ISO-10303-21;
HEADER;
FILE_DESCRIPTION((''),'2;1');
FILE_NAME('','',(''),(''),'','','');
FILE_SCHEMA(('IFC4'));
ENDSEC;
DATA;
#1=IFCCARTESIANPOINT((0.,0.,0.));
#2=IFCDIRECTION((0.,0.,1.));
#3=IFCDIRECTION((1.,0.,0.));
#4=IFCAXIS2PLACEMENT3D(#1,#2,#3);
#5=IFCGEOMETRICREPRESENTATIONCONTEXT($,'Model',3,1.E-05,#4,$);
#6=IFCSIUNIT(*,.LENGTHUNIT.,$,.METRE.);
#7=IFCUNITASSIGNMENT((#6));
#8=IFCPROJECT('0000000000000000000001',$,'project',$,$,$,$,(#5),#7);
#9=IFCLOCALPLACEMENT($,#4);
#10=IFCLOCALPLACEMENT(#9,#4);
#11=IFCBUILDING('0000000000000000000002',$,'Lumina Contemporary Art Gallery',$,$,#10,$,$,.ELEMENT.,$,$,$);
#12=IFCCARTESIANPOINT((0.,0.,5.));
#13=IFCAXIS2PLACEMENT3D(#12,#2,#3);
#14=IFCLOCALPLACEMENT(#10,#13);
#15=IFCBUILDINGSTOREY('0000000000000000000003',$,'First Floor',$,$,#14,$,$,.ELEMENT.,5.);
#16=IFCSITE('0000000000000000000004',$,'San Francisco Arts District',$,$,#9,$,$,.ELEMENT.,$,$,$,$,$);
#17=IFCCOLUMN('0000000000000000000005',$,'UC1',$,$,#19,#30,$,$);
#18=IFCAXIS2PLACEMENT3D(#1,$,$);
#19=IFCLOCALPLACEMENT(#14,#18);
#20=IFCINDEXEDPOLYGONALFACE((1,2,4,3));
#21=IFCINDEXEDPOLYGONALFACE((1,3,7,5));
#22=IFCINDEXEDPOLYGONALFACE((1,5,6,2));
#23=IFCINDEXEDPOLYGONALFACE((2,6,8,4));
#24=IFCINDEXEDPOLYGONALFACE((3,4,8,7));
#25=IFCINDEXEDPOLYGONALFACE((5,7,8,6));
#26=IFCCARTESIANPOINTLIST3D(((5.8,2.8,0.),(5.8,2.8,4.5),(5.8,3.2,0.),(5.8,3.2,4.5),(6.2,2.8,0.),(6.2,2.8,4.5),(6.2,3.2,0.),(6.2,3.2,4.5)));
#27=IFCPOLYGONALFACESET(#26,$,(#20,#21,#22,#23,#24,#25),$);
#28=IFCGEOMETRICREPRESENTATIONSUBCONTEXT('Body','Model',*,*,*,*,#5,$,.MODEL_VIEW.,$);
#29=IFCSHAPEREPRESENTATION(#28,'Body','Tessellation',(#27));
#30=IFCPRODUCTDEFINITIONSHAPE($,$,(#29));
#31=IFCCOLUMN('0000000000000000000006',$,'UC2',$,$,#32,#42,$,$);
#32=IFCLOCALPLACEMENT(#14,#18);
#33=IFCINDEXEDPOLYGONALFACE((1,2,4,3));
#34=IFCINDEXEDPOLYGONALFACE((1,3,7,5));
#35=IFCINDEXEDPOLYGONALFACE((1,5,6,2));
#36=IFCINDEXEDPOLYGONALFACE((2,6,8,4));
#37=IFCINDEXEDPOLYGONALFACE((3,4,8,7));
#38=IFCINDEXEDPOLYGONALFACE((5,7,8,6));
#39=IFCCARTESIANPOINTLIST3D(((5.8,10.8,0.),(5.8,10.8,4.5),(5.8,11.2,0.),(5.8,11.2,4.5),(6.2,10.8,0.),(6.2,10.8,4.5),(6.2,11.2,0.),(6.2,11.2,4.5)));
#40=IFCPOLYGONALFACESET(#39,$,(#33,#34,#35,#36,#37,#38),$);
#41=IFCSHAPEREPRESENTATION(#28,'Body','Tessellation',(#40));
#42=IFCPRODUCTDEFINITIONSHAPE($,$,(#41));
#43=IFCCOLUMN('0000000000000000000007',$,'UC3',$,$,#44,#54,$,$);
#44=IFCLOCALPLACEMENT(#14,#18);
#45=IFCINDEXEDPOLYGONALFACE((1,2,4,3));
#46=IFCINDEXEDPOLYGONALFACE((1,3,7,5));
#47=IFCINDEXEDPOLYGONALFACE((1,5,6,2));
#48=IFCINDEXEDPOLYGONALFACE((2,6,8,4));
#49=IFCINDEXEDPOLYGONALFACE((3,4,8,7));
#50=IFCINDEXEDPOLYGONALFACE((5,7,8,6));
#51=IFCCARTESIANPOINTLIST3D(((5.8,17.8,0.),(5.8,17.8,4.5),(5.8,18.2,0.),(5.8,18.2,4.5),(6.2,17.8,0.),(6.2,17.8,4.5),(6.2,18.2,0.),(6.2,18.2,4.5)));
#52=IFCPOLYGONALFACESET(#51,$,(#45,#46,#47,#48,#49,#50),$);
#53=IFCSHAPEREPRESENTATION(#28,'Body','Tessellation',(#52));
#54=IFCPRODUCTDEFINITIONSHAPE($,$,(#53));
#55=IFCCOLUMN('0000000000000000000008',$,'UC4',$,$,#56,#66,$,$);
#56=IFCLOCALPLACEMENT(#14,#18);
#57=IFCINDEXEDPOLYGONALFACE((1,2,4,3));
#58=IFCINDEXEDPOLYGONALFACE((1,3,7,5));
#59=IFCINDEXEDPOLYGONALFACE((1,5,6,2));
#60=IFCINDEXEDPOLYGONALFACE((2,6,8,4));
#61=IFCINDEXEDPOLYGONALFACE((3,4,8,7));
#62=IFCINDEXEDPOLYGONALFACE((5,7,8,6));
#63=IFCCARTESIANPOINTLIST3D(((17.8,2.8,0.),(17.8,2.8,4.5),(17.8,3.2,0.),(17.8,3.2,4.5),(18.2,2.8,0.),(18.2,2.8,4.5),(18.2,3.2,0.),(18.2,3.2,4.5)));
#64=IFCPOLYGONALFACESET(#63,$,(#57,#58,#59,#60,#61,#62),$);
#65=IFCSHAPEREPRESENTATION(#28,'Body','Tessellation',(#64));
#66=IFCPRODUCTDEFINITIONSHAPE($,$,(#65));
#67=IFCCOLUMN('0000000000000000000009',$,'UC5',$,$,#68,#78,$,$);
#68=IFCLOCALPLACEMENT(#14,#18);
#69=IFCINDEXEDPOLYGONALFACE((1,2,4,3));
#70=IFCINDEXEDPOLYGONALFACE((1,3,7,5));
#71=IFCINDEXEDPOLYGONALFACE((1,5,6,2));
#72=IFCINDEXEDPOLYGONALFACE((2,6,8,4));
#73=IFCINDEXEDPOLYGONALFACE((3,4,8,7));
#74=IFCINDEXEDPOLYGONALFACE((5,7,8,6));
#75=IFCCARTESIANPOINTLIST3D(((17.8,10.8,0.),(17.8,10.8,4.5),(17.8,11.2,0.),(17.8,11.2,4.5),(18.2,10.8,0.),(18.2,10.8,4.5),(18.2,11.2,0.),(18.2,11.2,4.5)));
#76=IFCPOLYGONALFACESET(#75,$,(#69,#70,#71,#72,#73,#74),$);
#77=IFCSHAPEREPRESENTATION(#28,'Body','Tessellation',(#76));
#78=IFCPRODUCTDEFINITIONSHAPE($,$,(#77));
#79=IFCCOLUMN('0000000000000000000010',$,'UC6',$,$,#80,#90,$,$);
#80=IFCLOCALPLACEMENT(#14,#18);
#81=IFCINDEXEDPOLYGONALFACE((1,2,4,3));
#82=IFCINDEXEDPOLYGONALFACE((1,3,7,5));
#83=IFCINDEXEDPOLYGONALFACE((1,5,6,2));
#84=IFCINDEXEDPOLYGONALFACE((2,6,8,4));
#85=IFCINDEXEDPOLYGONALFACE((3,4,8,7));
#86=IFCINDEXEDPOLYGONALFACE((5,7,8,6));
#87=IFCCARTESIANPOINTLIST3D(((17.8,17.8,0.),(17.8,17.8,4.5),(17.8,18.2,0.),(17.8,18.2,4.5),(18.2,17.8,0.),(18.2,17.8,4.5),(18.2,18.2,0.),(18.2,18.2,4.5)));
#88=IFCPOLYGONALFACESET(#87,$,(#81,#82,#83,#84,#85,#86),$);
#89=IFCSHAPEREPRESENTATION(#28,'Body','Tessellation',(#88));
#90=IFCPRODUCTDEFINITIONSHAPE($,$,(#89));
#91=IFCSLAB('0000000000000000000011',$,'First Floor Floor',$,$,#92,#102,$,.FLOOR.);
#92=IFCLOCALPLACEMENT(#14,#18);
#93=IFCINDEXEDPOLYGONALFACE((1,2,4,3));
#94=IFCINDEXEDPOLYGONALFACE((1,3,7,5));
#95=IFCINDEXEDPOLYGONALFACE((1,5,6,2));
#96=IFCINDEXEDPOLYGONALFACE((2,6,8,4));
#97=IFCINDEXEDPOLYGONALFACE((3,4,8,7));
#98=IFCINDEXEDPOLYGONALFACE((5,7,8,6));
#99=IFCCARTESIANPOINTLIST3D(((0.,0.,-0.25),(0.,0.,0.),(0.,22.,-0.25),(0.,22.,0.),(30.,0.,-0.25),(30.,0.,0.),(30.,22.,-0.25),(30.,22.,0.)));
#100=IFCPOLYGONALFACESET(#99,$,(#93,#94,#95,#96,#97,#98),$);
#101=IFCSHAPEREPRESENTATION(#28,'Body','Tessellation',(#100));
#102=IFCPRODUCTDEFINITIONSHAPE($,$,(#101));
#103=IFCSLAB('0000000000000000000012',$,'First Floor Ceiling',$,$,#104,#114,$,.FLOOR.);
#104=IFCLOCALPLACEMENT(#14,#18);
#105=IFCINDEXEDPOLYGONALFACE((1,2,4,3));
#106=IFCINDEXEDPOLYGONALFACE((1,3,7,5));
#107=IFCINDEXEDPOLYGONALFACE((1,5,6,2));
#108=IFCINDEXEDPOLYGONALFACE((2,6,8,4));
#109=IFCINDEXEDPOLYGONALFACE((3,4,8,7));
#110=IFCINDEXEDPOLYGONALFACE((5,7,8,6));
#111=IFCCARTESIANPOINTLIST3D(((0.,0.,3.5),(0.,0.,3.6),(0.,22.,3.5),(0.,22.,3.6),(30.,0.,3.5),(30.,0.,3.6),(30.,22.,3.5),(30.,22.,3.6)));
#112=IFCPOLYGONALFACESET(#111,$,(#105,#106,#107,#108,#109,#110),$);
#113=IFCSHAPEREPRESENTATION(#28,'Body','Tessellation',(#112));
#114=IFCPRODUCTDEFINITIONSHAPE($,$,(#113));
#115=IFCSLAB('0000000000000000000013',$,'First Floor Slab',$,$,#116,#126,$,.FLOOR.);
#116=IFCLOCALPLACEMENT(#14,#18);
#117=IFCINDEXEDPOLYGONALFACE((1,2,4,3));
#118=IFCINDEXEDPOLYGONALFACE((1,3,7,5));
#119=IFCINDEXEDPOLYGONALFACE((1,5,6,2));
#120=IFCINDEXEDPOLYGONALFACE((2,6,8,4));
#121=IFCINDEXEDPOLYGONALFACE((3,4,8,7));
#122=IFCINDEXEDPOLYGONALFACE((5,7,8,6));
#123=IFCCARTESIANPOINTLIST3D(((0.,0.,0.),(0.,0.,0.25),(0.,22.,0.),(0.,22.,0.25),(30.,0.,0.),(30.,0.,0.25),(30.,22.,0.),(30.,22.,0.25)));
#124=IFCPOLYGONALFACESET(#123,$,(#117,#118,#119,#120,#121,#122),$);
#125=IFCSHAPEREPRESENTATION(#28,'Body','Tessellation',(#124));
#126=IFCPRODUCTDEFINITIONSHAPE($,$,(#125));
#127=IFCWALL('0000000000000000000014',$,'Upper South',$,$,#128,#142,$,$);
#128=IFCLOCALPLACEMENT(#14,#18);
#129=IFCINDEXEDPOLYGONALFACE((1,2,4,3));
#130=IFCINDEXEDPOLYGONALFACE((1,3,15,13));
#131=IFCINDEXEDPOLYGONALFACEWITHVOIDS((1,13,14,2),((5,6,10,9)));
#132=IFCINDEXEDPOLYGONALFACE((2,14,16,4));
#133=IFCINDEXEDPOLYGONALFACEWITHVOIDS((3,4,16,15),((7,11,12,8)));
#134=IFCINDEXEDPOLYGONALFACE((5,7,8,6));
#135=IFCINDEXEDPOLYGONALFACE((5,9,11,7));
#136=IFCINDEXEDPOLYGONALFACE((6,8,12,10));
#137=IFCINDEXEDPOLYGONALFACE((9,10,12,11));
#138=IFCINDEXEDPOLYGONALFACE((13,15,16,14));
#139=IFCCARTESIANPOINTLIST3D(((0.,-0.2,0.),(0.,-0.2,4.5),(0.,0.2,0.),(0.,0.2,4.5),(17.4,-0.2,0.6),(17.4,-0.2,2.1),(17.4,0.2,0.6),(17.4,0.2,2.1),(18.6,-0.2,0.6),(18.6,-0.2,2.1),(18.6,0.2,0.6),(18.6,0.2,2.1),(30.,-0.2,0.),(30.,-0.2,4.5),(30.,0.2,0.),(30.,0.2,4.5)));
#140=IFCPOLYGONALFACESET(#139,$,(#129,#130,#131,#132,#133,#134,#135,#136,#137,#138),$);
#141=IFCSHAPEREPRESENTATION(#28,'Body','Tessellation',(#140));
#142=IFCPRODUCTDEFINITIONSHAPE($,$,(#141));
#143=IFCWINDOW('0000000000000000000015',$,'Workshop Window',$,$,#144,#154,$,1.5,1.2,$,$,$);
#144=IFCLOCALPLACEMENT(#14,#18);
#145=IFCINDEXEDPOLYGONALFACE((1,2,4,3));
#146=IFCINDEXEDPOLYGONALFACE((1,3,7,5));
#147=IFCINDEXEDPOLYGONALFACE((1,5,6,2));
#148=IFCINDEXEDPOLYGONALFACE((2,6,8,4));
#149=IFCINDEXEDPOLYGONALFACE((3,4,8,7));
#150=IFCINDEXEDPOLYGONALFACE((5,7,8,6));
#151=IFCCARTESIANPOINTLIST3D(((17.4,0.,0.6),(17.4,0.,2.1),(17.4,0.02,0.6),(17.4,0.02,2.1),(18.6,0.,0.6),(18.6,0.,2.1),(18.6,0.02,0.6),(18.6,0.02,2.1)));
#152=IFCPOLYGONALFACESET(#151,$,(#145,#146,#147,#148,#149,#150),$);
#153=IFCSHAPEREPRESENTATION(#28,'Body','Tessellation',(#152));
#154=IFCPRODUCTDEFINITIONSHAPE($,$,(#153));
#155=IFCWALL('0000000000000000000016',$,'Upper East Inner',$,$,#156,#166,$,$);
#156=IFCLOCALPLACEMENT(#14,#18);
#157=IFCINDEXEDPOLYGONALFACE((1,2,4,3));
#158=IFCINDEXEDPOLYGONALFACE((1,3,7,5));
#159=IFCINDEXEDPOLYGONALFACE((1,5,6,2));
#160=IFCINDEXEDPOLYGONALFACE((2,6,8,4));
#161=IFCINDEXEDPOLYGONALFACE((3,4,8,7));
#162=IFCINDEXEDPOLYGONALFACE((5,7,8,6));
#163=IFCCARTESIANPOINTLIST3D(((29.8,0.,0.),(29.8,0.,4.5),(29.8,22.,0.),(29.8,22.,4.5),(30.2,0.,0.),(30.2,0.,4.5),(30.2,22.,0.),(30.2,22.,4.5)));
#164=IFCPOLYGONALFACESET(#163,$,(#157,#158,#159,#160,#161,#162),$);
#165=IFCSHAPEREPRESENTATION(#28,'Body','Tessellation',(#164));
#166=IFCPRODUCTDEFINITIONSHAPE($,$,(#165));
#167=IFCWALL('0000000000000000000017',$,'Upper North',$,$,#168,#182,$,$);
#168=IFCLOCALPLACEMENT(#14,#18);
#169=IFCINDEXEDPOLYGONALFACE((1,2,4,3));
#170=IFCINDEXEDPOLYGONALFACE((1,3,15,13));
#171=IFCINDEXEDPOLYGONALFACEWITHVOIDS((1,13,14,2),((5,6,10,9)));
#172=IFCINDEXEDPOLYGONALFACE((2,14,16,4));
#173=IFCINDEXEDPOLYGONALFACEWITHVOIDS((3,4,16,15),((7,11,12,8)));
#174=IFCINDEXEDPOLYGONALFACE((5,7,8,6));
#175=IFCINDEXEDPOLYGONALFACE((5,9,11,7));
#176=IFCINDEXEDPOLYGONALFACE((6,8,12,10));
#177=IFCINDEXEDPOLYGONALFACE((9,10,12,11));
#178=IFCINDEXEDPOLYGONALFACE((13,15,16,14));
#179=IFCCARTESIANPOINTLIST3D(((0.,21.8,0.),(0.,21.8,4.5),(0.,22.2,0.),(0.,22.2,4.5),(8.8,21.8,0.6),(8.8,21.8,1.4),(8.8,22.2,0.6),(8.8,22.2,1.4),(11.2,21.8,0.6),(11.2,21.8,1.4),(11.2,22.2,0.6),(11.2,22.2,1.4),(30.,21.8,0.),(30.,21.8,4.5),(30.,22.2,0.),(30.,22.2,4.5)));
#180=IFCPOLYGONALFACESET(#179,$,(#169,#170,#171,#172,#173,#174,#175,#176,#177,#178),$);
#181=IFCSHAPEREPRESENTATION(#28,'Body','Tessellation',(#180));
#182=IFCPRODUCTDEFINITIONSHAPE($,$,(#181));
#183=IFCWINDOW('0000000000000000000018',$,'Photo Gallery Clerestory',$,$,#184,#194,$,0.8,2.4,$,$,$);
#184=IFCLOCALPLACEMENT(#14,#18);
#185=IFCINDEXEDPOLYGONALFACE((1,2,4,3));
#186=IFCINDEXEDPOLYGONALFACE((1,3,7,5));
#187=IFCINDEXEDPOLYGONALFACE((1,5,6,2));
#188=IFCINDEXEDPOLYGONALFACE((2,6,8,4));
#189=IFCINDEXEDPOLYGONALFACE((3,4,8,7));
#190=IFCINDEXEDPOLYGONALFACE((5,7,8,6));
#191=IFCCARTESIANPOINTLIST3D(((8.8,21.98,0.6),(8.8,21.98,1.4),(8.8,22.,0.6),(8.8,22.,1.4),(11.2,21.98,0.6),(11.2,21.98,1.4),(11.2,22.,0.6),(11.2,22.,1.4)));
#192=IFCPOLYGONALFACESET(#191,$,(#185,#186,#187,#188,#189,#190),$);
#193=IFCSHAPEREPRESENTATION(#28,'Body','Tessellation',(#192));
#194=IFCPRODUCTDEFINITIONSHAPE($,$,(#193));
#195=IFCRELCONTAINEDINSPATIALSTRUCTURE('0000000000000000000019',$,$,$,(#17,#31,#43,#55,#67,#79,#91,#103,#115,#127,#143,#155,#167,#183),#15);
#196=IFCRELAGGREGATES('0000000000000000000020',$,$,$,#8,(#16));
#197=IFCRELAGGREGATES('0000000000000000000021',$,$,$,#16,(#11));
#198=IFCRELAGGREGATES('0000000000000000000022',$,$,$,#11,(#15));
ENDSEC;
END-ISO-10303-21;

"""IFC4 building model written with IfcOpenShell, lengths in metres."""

from ifc_helpers import new_model, si_unit, frame, origin_with_axes, place, context, subcontext, project, spatial, polyline, outline, extrude, element, fill, save


model = new_model("IFC4")

# Units and contexts
model_context = context("Model", 3, precision=1e-05, world=origin_with_axes())
body_context = subcontext(model_context, "Body", "Model", "MODEL_VIEW")
ifc_project = project(units=[si_unit("LENGTHUNIT", "METRE")], contexts=[model_context])

# Site, building, storey
site_placement = place(None, origin_with_axes())
site = spatial("IfcSite", under=ifc_project, at=site_placement, Name="San Francisco Arts District", CompositionType="ELEMENT")
building_placement = place(site_placement, origin_with_axes())
building = spatial("IfcBuilding", under=site, at=building_placement, Name="Lumina Contemporary Art Gallery", CompositionType="ELEMENT")
storey_placement = place(building_placement, frame((0.0, 0.0, 5.0), z_axis=(0.0, 0.0, 1.0), x_axis=(1.0, 0.0, 0.0)))
storey = spatial("IfcBuildingStorey", under=building, at=storey_placement, Name="First Floor", CompositionType="ELEMENT", Elevation=5.0)

# Columns
column_1_placement = place(storey_placement, origin_with_axes())
element("IfcColumn", 1, at=column_1_placement, inside=storey, Name="UC1", context=body_context, shape_type="SweptSolid", body=[
    extrude(outline(polyline([(5.8, 2.8, 0.0), (6.2, 2.8, 0.0), (6.2, 3.2, 0.0), (5.8, 3.2, 0.0), (5.8, 2.8, 0.0)])), None, (0.0, 0.0, 1.0), 4.5),
])
column_2_placement = place(storey_placement, origin_with_axes())
element("IfcColumn", 2, at=column_2_placement, inside=storey, Name="UC2", context=body_context, shape_type="SweptSolid", body=[
    extrude(outline(polyline([(5.8, 10.8, 0.0), (6.2, 10.8, 0.0), (6.2, 11.2, 0.0), (5.8, 11.2, 0.0), (5.8, 10.8, 0.0)])), None, (0.0, 0.0, 1.0), 4.5),
])
column_3_placement = place(storey_placement, origin_with_axes())
element("IfcColumn", 3, at=column_3_placement, inside=storey, Name="UC3", context=body_context, shape_type="SweptSolid", body=[
    extrude(outline(polyline([(5.8, 17.8, 0.0), (6.2, 17.8, 0.0), (6.2, 18.2, 0.0), (5.8, 18.2, 0.0), (5.8, 17.8, 0.0)])), None, (0.0, 0.0, 1.0), 4.5),
])
column_4_placement = place(storey_placement, origin_with_axes())
element("IfcColumn", 4, at=column_4_placement, inside=storey, Name="UC4", context=body_context, shape_type="SweptSolid", body=[
    extrude(outline(polyline([(17.8, 2.8, 0.0), (18.2, 2.8, 0.0), (18.2, 3.2, 0.0), (17.8, 3.2, 0.0), (17.8, 2.8, 0.0)])), None, (0.0, 0.0, 1.0), 4.5),
])
column_5_placement = place(storey_placement, origin_with_axes())
element("IfcColumn", 5, at=column_5_placement, inside=storey, Name="UC5", context=body_context, shape_type="SweptSolid", body=[
    extrude(outline(polyline([(17.8, 10.8, 0.0), (18.2, 10.8, 0.0), (18.2, 11.2, 0.0), (17.8, 11.2, 0.0), (17.8, 10.8, 0.0)])), None, (0.0, 0.0, 1.0), 4.5),
])
column_6_placement = place(storey_placement, origin_with_axes())
element("IfcColumn", 6, at=column_6_placement, inside=storey, Name="UC6", context=body_context, shape_type="SweptSolid", body=[
    extrude(outline(polyline([(17.8, 17.8, 0.0), (18.2, 17.8, 0.0), (18.2, 18.2, 0.0), (17.8, 18.2, 0.0), (17.8, 17.8, 0.0)])), None, (0.0, 0.0, 1.0), 4.5),
])

# Slabs
slab_1_placement = place(storey_placement, origin_with_axes())
element("IfcSlab", 7, at=slab_1_placement, inside=storey, Name="First Floor Floor", PredefinedType="FLOOR", context=body_context, shape_type="SweptSolid", body=[
    extrude(outline(polyline([(0.0, 0.0, -0.25), (30.0, 0.0, -0.25), (30.0, 22.0, -0.25), (0.0, 22.0, -0.25), (0.0, 0.0, -0.25)])), None, (0.0, 0.0, 1.0), 0.25),
])
slab_2_placement = place(storey_placement, origin_with_axes())
element("IfcSlab", 8, at=slab_2_placement, inside=storey, Name="First Floor Ceiling", PredefinedType="FLOOR", context=body_context, shape_type="SweptSolid", body=[
    extrude(outline(polyline([(0.0, 0.0, 3.5), (30.0, 0.0, 3.5), (30.0, 22.0, 3.5), (0.0, 22.0, 3.5), (0.0, 0.0, 3.5)])), None, (0.0, 0.0, 1.0), 0.1),
])
slab_3_placement = place(storey_placement, origin_with_axes())
element("IfcSlab", 9, at=slab_3_placement, inside=storey, Name="First Floor Slab", PredefinedType="FLOOR", context=body_context, shape_type="SweptSolid", body=[
    extrude(outline(polyline([(0.0, 0.0, 0.0), (30.0, 0.0, 0.0), (30.0, 22.0, 0.0), (0.0, 22.0, 0.0), (0.0, 0.0, 0.0)])), None, (0.0, 0.0, 1.0), 0.25),
])

# Wall, opening, window
wall_1_placement = place(storey_placement, origin_with_axes())
wall_1 = element("IfcWall", 10, at=wall_1_placement, inside=storey, Name="Upper South", context=body_context, shape_type="SweptSolid", body=[
    extrude(outline(polyline([(0.0, -0.2, 0.0), (30.0, -0.2, 0.0), (30.0, 0.2, 0.0), (0.0, 0.2, 0.0), (0.0, -0.2, 0.0)])), None, (0.0, 0.0, 1.0), 4.5),
])
opening_1_placement = place(storey_placement, origin_with_axes())
opening_1 = element("IfcOpeningElement", 11, at=opening_1_placement, inside=storey, cuts=wall_1, context=body_context, shape_type="SweptSolid", body=[
    extrude(outline(polyline([(17.4, -0.4, 0.6), (18.6, -0.4, 0.6), (18.6, 0.4, 0.6), (17.4, 0.4, 0.6), (17.4, -0.4, 0.6)])), None, (0.0, 0.0, 1.0), 1.5),
])
window_1_placement = place(storey_placement, origin_with_axes())
window_1 = element("IfcWindow", 12, at=window_1_placement, inside=storey, Name="Workshop Window", OverallHeight=1.5, OverallWidth=1.2, context=body_context, shape_type="SweptSolid", body=[
    extrude(outline(polyline([(17.4, 0.0, 0.6), (18.6, 0.0, 0.6), (18.6, 0.02, 0.6), (17.4, 0.02, 0.6), (17.4, 0.0, 0.6)])), None, (0.0, 0.0, 1.0), 1.5),
])
fill(opening_1, window_1)

# Wall
wall_2_placement = place(storey_placement, origin_with_axes())
element("IfcWall", 13, at=wall_2_placement, inside=storey, Name="Upper East Inner", context=body_context, shape_type="SweptSolid", body=[
    extrude(outline(polyline([(30.2, 0.0, 0.0), (30.2, 22.0, 0.0), (29.8, 22.0, 0.0), (29.8, 0.0, 0.0), (30.2, 0.0, 0.0)])), None, (0.0, 0.0, 1.0), 4.5),
])

# Wall, opening, window
wall_3_placement = place(storey_placement, origin_with_axes())
wall_3 = element("IfcWall", 14, at=wall_3_placement, inside=storey, Name="Upper North", context=body_context, shape_type="SweptSolid", body=[
    extrude(outline(polyline([(30.0, 22.2, 0.0), (0.0, 22.2, 0.0), (0.0, 21.8, 0.0), (30.0, 21.8, 0.0), (30.0, 22.2, 0.0)])), None, (0.0, 0.0, 1.0), 4.5),
])
opening_2_placement = place(storey_placement, origin_with_axes())
opening_2 = element("IfcOpeningElement", 15, at=opening_2_placement, inside=storey, cuts=wall_3, context=body_context, shape_type="SweptSolid", body=[
    extrude(outline(polyline([(11.2, 22.4, 0.6), (8.8, 22.4, 0.6), (8.8, 21.6, 0.6), (11.2, 21.6, 0.6), (11.2, 22.4, 0.6)])), None, (0.0, 0.0, 1.0), 0.8),
])
window_2_placement = place(storey_placement, origin_with_axes())
window_2 = element("IfcWindow", 16, at=window_2_placement, inside=storey, Name="Photo Gallery Clerestory", OverallHeight=0.8, OverallWidth=2.4, context=body_context, shape_type="SweptSolid", body=[
    extrude(outline(polyline([(11.2, 22.0, 0.6), (8.8, 22.0, 0.6), (8.8, 21.98, 0.6), (11.2, 21.98, 0.6), (11.2, 22.0, 0.6)])), None, (0.0, 0.0, 1.0), 0.8),
])
fill(opening_2, window_2)

save(model, "model.ifc")
